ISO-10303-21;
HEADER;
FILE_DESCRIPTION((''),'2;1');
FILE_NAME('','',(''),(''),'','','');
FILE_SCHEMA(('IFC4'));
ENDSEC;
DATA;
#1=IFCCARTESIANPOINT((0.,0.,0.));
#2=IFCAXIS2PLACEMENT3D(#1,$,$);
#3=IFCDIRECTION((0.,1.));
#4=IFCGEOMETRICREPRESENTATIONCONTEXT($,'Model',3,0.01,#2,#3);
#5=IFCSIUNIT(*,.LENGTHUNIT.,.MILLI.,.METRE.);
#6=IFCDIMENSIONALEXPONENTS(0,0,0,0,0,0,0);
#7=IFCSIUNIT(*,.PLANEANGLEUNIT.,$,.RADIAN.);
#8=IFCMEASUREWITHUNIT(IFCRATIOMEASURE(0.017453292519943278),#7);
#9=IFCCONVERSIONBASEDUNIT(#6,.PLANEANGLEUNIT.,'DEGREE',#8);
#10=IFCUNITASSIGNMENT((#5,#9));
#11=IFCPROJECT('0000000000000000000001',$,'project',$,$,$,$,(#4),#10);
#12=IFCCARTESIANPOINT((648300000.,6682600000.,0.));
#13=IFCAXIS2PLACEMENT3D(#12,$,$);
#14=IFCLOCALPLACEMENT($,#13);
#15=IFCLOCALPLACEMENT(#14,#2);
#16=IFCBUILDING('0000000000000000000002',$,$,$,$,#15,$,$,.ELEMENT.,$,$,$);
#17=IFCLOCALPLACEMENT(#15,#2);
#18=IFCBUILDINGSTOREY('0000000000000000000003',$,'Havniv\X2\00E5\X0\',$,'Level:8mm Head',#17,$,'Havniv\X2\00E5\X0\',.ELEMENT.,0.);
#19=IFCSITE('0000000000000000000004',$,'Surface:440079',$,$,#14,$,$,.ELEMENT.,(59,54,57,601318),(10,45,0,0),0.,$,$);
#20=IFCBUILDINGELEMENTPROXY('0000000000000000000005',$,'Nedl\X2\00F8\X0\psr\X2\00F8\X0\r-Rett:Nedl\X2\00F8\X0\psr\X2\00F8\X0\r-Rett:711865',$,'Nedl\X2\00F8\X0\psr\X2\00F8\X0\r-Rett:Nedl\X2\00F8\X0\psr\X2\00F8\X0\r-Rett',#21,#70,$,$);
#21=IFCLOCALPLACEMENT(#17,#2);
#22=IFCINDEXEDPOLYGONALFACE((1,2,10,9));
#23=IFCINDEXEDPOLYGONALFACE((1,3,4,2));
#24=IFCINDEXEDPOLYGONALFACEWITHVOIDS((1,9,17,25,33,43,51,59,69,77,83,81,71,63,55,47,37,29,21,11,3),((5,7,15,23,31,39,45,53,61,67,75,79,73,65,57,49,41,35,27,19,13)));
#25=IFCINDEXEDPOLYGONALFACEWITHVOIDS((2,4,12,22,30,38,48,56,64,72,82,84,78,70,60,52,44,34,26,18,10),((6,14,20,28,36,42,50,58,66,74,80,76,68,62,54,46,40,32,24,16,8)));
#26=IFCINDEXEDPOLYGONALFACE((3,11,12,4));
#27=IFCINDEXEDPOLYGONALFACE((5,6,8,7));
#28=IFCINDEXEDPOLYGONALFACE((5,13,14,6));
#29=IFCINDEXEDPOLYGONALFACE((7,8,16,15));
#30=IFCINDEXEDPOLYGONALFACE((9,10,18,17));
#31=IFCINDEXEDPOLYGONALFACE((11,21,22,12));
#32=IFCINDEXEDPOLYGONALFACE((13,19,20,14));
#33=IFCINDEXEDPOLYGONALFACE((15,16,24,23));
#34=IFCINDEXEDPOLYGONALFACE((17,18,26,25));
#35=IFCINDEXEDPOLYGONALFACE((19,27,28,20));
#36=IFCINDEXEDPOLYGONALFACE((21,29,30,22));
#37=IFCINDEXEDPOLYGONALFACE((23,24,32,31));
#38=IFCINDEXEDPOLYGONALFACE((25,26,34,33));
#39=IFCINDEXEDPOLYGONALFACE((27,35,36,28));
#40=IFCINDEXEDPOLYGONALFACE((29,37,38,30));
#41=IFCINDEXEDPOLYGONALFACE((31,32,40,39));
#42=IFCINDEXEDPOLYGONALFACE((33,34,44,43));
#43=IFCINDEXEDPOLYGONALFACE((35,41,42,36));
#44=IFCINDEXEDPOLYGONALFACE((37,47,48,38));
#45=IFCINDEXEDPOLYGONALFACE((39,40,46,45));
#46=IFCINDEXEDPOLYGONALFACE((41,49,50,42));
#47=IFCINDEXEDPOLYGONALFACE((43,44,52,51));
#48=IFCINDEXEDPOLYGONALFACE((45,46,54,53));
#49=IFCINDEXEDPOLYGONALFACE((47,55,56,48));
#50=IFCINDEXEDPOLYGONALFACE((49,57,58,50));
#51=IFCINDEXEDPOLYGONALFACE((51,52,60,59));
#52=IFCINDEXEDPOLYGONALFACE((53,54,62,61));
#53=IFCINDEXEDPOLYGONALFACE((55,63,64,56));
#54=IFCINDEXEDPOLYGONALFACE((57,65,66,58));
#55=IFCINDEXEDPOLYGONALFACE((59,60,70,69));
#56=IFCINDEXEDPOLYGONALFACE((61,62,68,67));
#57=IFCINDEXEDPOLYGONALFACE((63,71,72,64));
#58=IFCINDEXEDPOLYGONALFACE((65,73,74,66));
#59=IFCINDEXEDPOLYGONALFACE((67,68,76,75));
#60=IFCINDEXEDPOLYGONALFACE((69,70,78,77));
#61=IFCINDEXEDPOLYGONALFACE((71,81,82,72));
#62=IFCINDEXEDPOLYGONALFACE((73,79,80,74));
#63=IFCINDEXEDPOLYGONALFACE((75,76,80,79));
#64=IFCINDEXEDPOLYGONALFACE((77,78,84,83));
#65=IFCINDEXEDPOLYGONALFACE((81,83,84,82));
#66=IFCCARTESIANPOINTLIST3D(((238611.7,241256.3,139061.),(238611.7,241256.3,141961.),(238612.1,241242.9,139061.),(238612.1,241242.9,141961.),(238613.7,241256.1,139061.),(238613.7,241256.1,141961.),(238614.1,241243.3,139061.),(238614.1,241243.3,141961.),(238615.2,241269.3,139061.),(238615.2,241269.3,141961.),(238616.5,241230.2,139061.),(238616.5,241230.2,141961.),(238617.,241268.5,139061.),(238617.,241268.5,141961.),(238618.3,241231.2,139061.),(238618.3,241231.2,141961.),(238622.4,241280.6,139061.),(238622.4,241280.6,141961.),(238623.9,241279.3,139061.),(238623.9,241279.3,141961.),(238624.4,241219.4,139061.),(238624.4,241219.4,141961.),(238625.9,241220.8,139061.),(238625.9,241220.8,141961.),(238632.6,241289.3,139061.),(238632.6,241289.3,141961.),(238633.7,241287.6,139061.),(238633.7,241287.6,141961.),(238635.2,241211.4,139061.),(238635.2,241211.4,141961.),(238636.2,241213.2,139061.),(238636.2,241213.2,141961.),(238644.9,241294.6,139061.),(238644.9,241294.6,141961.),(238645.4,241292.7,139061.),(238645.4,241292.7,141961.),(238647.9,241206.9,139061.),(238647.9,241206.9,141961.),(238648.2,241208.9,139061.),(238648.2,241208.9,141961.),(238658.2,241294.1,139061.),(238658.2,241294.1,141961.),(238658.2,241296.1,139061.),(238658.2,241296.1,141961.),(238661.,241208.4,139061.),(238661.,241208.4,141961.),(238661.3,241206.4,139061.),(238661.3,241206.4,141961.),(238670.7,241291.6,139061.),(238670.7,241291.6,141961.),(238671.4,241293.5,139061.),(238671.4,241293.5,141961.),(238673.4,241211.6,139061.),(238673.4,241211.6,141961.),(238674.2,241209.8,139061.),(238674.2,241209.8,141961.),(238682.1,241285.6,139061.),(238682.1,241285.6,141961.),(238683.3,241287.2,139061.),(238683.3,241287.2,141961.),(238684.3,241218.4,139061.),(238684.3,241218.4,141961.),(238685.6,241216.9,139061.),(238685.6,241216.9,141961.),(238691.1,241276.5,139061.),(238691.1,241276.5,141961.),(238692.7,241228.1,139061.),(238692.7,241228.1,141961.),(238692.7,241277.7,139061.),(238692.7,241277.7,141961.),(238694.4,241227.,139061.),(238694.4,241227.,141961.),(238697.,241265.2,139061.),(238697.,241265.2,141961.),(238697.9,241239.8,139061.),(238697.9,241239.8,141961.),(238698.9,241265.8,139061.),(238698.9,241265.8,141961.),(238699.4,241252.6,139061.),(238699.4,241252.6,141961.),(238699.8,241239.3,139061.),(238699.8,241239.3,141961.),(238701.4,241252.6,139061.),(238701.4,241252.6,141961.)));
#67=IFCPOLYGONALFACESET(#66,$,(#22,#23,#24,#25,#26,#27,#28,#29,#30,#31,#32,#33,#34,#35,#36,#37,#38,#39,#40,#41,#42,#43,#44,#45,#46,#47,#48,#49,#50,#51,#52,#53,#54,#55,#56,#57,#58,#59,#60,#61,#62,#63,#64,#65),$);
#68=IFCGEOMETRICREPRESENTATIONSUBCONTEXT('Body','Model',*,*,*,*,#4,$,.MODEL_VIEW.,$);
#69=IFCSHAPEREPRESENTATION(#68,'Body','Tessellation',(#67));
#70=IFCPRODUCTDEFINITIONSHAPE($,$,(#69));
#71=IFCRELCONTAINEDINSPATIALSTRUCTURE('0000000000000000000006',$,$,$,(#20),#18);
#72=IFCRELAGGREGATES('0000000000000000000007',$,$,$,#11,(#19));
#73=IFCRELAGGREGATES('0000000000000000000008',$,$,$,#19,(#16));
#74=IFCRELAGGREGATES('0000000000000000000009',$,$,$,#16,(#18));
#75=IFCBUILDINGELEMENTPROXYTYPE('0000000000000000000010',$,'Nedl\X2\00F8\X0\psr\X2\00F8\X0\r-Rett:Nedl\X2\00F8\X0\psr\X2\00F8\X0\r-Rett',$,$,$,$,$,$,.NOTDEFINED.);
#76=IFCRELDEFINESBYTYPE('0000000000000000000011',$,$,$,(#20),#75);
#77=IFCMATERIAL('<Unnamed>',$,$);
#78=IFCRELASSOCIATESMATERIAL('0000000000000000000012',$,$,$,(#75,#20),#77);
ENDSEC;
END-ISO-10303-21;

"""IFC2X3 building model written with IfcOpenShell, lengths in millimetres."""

from ifc_helpers import new_model, entity, si_unit, converted_unit, direction, frame, frame_2d, origin, place, context, subcontext, project, spatial, hollow_circle, extrude, source, transform, mapped, material, type_object, type_shapes, element, save


model = new_model("IFC2X3")

# Units and contexts
model_context = context("Model", 3, precision=0.01, world=origin(), true_north=direction((0.0, 1.0)))
body_context = subcontext(model_context, "Body", "Model", "MODEL_VIEW")
ifc_project = project(units=[si_unit("LENGTHUNIT", "METRE", prefix="MILLI"), converted_unit("PLANEANGLEUNIT", "DEGREE", entity("IfcRatioMeasure", 0.017453292519943278), si_unit("PLANEANGLEUNIT", "RADIAN"), dimensions=[0, 0, 0, 0, 0, 0, 0])], contexts=[model_context])

# Site, building, storey
site_placement = place(None, frame((648300000.0, 6682600000.0, 0.0)))
site = spatial("IfcSite", under=ifc_project, at=site_placement, Name="Surface:440079", CompositionType="ELEMENT", RefLatitude=(59, 54, 57, 601318), RefLongitude=(10, 45, 0, 0), RefElevation=0.0)
building_placement = place(site_placement, origin())
building = spatial("IfcBuilding", under=site, at=building_placement, CompositionType="ELEMENT")
storey_placement = place(building_placement, origin())
storey = spatial("IfcBuildingStorey", under=building, at=storey_placement, Name="Havnivå", ObjectType="Level:8mm Head", LongName="Havnivå", CompositionType="ELEMENT", Elevation=0.0)

# Building element proxy
ifc_material_1 = material(Name="<Unnamed>")
building_element_proxy_type = type_object("IfcBuildingElementProxyType", Name="Nedløpsrør-Rett:Nedløpsrør-Rett", PredefinedType="NOTDEFINED", material=ifc_material_1)
shared_shape_1 = source(origin(), body_context, "Body", "SweptSolid", [
    extrude(hollow_circle(Radius=45.0, WallThickness=2.0, at=frame_2d((0.0, 0.0), x_axis=(1.0, 0.0))), frame((0.0, 0.0, 0.0), z_axis=(0.0, 0.0, 1.0), x_axis=(-1.0, 0.0, 0.0)), (0.0, 0.0, 1.0), 2900.0),
])
type_shapes(building_element_proxy_type, [shared_shape_1])
proxy_placement = place(storey_placement, frame((238656.4, 241251.1, 139061.0), z_axis=(0.0, 0.0, 1.0), x_axis=(0.755467, -0.655187, 0.0)))
element("IfcBuildingElementProxy", 1, at=proxy_placement, inside=storey, type_object=building_element_proxy_type, material=ifc_material_1, Name="Nedløpsrør-Rett:Nedløpsrør-Rett:711865", ObjectType="Nedløpsrør-Rett:Nedløpsrør-Rett", context=body_context, shape_type="MappedRepresentation", body=[
    mapped(shared_shape_1, transform((0.0, 0.0, 0.0), scale=1.0)),
])

save(model, "model.ifc")
